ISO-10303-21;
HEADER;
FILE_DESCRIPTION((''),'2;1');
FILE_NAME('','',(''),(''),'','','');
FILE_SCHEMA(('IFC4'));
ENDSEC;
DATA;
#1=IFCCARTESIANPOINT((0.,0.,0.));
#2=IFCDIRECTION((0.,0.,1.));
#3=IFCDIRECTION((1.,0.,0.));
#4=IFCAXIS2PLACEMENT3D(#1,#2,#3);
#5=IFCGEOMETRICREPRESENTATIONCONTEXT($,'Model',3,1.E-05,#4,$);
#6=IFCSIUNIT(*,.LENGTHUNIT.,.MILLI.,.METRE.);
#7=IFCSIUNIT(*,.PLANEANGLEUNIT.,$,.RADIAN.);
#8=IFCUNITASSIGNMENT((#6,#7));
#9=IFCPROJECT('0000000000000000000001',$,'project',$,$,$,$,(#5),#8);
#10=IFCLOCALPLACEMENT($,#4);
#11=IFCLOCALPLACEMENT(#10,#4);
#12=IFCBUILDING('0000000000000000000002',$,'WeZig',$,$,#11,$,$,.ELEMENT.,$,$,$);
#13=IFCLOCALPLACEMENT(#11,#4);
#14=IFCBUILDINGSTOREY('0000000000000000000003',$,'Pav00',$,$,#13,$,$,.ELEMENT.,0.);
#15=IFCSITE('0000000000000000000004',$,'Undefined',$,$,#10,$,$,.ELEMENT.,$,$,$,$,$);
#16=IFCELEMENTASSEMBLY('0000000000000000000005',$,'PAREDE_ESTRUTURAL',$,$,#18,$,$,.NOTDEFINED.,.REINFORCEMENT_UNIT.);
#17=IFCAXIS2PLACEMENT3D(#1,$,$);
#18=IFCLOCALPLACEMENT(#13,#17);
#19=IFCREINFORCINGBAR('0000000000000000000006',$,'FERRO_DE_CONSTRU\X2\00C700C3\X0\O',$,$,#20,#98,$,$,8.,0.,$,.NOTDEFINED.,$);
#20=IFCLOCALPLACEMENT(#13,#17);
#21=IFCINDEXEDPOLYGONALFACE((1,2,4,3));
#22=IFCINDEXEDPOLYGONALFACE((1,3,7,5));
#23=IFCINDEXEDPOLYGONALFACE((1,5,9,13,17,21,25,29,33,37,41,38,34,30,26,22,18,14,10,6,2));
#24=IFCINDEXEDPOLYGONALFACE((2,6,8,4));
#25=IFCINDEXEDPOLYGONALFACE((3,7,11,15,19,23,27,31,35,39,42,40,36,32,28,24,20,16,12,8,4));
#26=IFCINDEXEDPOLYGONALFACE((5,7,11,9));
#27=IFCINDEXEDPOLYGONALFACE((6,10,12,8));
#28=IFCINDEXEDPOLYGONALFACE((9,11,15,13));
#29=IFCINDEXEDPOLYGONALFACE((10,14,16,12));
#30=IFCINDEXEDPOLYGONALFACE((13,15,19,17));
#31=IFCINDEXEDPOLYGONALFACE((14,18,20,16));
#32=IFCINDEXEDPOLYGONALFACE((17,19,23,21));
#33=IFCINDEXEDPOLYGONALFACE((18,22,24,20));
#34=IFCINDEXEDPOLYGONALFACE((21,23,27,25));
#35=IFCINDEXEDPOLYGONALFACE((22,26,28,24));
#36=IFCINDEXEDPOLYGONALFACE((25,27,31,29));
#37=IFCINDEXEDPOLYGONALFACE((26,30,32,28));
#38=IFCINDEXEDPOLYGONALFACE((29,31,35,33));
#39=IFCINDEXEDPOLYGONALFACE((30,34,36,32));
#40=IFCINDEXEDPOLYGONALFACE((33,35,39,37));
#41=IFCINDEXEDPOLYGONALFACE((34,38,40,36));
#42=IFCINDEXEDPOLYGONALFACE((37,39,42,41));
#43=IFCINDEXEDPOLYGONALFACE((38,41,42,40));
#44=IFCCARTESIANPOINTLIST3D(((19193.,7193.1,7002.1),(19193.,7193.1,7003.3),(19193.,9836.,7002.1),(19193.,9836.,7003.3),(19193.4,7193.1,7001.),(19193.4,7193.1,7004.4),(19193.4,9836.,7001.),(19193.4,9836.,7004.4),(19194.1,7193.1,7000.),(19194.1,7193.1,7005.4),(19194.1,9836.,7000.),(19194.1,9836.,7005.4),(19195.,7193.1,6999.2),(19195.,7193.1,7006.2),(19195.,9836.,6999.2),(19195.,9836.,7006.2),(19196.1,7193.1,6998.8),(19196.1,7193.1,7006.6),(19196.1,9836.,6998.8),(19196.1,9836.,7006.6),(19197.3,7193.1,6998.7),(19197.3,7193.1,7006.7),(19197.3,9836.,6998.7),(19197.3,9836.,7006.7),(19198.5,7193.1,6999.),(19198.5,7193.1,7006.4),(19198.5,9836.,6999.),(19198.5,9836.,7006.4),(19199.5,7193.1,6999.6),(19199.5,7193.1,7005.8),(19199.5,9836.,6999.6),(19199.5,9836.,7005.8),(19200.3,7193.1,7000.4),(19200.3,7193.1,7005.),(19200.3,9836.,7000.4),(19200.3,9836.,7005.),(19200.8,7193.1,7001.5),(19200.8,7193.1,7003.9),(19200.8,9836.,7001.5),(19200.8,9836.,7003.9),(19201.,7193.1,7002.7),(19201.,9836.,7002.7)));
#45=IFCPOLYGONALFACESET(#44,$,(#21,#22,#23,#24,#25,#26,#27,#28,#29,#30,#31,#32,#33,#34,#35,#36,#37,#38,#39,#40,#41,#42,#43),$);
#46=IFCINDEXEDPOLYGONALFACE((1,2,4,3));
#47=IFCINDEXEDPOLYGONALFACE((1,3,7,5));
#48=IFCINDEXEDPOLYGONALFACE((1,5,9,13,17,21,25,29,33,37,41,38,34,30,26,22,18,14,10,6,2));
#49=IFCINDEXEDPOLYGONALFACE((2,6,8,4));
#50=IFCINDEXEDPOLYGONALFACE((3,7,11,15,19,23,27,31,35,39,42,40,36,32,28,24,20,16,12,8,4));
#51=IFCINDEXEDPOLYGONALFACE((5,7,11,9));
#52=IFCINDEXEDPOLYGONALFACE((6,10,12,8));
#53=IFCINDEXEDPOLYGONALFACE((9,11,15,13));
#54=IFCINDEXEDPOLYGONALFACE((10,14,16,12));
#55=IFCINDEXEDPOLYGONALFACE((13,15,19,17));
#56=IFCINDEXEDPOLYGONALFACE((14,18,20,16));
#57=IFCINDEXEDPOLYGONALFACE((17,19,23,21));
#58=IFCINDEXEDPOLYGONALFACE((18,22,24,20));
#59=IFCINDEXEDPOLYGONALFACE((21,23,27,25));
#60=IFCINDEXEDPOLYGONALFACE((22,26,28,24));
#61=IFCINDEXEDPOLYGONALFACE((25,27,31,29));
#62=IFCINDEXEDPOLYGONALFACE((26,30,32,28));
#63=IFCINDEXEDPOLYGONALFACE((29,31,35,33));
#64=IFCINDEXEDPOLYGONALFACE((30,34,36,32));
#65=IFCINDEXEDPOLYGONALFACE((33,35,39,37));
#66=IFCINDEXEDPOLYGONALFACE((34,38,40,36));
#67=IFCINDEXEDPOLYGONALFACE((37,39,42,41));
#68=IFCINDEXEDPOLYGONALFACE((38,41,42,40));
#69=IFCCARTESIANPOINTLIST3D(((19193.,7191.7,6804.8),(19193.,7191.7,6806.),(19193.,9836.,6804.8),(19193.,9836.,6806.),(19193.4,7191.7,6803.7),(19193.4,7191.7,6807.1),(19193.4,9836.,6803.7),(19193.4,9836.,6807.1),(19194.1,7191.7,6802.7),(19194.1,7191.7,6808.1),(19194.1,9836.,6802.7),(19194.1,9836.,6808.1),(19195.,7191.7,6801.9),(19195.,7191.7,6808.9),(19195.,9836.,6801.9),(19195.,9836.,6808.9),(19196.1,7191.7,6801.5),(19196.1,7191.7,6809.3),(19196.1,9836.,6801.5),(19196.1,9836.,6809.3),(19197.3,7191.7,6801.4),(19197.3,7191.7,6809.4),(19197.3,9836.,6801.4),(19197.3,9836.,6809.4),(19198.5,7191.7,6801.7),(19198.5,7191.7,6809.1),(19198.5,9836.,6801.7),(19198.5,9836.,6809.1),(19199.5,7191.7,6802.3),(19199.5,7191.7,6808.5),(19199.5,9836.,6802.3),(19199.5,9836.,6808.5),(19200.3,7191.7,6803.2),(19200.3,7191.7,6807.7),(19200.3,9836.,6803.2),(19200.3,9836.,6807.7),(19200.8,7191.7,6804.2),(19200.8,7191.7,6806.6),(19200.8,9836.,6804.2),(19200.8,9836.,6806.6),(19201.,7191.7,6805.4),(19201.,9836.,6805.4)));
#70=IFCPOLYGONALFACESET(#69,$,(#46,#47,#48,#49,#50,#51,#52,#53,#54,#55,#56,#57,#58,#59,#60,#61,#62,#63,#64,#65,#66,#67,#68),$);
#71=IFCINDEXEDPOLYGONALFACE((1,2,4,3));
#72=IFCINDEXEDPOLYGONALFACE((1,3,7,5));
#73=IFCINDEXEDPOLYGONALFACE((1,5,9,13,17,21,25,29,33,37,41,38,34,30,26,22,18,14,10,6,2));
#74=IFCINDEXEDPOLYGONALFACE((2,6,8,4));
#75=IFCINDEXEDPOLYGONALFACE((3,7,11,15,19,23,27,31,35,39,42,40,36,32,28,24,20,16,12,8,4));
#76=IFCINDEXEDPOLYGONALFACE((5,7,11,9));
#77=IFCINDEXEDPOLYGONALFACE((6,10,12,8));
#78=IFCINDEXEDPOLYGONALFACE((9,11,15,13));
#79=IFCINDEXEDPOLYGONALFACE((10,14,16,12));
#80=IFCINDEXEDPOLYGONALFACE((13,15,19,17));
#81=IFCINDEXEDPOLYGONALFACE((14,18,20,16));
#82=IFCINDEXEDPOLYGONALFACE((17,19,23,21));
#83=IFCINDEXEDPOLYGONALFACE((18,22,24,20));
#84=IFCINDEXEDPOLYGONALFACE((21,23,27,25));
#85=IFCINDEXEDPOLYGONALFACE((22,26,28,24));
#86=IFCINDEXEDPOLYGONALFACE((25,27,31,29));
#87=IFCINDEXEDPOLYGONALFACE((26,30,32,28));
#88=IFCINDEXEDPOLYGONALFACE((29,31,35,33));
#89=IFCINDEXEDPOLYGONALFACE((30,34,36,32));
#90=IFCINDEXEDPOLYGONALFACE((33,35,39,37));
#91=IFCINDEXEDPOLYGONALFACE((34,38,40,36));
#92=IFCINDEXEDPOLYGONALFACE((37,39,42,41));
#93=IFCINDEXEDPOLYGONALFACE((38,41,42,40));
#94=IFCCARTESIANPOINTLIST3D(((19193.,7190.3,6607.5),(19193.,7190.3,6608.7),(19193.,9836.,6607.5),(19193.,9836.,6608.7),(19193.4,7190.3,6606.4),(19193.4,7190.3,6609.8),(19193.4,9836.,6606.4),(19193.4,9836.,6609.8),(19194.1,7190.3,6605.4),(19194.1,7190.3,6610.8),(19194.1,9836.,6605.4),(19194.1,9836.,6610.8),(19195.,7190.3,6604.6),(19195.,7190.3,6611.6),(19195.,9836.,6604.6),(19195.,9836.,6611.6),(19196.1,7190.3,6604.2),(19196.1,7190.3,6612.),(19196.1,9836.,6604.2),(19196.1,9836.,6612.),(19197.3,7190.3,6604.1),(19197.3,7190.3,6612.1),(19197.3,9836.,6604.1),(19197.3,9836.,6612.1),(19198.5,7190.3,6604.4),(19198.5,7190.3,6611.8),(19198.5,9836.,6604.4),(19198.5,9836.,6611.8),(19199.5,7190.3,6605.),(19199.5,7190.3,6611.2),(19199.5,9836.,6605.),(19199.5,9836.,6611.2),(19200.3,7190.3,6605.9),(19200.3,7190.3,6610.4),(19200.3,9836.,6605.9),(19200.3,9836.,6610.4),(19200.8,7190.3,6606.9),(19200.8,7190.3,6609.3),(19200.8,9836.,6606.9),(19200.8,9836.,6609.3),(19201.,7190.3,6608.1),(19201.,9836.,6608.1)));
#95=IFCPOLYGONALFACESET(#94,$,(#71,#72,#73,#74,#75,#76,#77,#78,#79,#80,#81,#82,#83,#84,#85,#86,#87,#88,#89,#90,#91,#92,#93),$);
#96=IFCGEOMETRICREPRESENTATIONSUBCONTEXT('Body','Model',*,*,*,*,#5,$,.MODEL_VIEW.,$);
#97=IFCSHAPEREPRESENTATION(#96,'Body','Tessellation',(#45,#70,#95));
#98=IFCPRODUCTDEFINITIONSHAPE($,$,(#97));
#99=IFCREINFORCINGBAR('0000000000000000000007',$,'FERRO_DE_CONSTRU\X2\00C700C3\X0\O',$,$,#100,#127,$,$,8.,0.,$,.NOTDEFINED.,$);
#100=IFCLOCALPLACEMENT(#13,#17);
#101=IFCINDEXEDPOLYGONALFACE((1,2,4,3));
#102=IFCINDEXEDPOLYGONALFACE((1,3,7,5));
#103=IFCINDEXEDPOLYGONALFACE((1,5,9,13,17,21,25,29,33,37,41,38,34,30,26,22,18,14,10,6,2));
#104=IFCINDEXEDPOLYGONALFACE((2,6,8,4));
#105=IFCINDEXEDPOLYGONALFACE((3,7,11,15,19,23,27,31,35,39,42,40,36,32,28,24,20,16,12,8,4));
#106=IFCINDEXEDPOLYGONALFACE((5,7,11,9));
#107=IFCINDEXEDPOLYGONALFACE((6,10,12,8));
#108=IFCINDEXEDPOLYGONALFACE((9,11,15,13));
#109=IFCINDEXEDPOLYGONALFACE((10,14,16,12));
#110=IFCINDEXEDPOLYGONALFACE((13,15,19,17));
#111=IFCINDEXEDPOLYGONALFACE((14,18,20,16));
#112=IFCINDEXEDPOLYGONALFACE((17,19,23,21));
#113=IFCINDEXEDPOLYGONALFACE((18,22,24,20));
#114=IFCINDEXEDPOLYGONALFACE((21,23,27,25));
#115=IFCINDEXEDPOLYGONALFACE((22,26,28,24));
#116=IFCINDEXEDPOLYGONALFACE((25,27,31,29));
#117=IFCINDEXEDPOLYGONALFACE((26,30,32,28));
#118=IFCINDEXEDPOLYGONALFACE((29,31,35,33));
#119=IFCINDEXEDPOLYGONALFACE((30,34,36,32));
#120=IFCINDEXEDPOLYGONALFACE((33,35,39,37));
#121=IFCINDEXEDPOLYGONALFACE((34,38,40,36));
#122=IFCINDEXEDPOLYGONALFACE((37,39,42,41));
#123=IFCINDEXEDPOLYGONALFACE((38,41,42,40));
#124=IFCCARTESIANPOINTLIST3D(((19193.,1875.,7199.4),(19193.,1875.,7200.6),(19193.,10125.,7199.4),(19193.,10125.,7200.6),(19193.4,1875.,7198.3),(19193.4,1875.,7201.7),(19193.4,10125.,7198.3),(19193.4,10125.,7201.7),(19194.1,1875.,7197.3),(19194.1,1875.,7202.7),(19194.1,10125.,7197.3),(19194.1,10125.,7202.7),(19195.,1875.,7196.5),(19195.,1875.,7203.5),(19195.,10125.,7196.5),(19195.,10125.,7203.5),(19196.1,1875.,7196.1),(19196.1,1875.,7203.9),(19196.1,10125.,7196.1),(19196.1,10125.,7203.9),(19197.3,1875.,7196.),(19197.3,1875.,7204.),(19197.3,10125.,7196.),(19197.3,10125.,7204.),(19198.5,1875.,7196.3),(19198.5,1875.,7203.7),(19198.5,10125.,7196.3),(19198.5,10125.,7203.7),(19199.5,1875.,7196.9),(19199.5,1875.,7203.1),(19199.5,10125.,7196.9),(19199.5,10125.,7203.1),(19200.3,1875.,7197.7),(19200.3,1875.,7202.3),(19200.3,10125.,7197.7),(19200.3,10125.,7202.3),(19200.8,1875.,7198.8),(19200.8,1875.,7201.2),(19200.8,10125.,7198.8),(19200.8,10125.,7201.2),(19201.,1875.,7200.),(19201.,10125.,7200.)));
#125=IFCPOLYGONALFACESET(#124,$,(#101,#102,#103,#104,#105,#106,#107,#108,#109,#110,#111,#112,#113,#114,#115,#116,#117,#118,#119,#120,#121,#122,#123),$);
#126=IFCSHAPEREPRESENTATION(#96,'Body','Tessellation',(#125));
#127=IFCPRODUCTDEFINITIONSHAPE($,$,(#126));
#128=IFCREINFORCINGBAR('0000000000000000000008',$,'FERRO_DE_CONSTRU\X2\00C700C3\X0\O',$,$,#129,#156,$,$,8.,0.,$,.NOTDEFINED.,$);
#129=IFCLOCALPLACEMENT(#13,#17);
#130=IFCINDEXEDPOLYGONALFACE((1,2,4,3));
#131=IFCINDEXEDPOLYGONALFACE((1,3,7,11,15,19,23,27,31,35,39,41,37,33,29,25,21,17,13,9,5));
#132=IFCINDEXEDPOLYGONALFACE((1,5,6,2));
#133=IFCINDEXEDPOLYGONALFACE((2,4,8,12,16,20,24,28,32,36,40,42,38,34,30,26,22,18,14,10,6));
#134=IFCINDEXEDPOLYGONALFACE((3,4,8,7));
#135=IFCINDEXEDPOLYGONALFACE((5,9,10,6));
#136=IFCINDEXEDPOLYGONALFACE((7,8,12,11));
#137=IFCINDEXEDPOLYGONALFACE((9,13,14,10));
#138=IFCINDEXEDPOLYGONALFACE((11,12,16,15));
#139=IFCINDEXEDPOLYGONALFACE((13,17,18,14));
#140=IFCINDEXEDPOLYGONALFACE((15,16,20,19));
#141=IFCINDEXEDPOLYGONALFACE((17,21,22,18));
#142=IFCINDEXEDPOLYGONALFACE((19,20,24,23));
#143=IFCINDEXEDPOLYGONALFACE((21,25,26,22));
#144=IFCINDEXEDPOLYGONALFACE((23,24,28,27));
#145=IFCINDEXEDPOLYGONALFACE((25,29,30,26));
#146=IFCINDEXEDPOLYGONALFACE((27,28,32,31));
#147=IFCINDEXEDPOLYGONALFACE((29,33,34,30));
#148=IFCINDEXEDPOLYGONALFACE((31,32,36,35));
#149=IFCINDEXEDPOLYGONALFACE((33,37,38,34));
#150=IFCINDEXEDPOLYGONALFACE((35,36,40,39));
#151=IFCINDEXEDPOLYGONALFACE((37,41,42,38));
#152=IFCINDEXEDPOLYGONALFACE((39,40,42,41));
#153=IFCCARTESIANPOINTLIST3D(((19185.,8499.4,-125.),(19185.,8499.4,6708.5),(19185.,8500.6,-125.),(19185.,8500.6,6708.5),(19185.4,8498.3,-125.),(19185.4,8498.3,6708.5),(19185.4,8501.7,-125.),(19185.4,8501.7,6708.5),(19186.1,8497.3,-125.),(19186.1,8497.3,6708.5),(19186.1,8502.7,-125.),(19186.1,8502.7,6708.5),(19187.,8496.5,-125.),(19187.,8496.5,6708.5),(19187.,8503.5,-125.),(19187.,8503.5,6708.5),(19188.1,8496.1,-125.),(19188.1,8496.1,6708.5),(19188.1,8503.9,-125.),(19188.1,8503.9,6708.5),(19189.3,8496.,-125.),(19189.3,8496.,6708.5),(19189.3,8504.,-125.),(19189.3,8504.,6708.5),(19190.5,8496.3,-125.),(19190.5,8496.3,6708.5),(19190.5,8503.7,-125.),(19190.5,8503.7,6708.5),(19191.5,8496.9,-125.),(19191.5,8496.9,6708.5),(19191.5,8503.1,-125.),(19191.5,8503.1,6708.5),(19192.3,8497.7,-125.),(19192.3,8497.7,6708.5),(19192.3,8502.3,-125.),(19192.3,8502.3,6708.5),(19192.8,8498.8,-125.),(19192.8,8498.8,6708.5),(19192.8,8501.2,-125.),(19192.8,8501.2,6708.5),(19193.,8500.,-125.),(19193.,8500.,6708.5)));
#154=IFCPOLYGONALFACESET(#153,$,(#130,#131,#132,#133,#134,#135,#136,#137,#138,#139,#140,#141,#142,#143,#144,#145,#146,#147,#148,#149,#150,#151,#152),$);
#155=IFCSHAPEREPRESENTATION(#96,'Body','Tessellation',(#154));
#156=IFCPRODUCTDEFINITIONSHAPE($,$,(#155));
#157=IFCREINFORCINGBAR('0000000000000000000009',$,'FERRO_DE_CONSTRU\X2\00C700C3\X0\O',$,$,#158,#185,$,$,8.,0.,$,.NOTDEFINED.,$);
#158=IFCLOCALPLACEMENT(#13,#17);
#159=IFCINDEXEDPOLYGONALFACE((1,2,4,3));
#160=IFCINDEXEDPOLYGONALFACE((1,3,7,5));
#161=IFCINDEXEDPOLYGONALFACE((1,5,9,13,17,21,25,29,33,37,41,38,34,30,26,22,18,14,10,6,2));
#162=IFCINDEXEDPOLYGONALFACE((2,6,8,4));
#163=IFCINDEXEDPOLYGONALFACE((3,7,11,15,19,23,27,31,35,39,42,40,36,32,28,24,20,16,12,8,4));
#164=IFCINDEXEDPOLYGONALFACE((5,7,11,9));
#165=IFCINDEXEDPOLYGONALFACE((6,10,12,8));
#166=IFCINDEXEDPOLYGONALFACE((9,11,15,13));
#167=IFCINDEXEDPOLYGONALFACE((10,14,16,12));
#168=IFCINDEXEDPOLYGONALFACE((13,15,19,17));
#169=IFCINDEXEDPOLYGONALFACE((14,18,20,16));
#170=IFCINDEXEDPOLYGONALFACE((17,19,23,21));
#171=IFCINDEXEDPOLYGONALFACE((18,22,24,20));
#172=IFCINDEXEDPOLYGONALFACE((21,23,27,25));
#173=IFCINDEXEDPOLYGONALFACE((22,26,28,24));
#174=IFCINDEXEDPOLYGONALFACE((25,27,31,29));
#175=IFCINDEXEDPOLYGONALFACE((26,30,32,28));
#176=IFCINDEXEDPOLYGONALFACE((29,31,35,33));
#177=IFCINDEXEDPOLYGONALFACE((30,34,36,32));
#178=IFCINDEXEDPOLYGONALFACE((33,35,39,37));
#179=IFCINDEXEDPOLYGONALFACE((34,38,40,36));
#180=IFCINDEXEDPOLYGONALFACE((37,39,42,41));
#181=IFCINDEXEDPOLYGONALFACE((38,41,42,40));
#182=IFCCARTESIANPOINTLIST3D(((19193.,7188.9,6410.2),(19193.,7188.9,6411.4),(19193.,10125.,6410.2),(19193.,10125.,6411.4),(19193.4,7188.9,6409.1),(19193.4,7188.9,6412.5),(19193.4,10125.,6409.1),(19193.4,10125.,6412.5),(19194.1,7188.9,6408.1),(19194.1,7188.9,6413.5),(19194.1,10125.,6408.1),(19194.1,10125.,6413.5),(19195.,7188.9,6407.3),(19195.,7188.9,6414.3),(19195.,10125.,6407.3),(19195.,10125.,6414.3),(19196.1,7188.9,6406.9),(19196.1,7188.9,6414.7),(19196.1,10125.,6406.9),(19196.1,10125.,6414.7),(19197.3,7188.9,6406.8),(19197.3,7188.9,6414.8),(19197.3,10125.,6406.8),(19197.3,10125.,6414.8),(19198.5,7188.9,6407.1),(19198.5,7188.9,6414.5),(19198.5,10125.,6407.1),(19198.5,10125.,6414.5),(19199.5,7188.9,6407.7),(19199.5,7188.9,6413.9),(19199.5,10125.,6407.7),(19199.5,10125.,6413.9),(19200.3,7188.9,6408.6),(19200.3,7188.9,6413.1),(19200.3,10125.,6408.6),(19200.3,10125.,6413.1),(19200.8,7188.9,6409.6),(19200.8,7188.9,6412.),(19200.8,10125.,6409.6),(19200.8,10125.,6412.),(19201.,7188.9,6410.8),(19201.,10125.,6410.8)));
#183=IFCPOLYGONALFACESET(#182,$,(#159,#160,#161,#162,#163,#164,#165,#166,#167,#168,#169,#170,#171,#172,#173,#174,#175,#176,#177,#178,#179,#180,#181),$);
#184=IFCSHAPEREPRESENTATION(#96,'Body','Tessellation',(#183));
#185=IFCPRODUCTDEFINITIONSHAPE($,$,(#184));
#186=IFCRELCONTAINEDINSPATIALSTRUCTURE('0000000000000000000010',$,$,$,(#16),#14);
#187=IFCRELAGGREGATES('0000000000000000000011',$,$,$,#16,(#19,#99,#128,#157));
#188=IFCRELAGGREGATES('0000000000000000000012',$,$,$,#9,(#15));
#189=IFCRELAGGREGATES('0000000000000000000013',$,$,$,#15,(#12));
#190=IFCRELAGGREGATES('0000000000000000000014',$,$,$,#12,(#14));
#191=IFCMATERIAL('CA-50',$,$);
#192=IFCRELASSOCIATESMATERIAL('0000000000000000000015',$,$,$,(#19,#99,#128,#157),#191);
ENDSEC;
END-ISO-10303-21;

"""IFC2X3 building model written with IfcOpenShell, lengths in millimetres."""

from ifc_helpers import new_model, entity, si_unit, frame, origin_with_axes, place, context, subcontext, project, spatial, source, transform, mapped, material, element, aggregate, save


model = new_model("IFC2X3")

# Units and contexts
model_context = context("Model", 3, precision=1e-05, world=origin_with_axes())
body_context = subcontext(model_context, "Body", "Model", "MODEL_VIEW")
ifc_project = project(units=[si_unit("LENGTHUNIT", "METRE", prefix="MILLI"), si_unit("PLANEANGLEUNIT", "RADIAN")], contexts=[model_context])

# Site, building, storey
site_placement = place(None, origin_with_axes())
site = spatial("IfcSite", under=ifc_project, at=site_placement, Name="Undefined", CompositionType="ELEMENT")
building_placement = place(site_placement, origin_with_axes())
building = spatial("IfcBuilding", under=site, at=building_placement, Name="WeZig", CompositionType="ELEMENT")
storey_placement = place(building_placement, origin_with_axes())
storey = spatial("IfcBuildingStorey", under=building, at=storey_placement, Name="Pav00", CompositionType="ELEMENT", Elevation=0.0)

# Element assembly
assembly_1_placement = place(storey_placement, origin_with_axes())
assembly_1 = element("IfcElementAssembly", 1, at=assembly_1_placement, inside=storey, Name="PAREDE_ESTRUTURAL", AssemblyPlace="NOTDEFINED", PredefinedType="REINFORCEMENT_UNIT")

# Reinforcing bars
ifc_material_1 = material(Name="CA-50")
shared_shape_1 = source(origin_with_axes(), body_context, "Body", "AdvancedSweptSolid", [
    entity("IfcSweptDiskSolid", entity("IfcTrimmedCurve", entity("IfcLine", entity("IfcCartesianPoint", [0.0, 0.0, 0.0]), entity("IfcVector", entity("IfcDirection", [1.0, 0.0, 0.0]), 1.0)), [entity("IfcParameterValue", 0.0)], [entity("IfcParameterValue", 2642.851014)], True, "PARAMETER"), 4.0, None, 0.0, 2642.9),
])
shared_shape_2 = source(origin_with_axes(), body_context, "Body", "AdvancedSweptSolid", [
    entity("IfcSweptDiskSolid", entity("IfcTrimmedCurve", entity("IfcLine", entity("IfcCartesianPoint", [0.0, 0.0, 0.0]), entity("IfcVector", entity("IfcDirection", [1.0, 0.0, 0.0]), 1.0)), [entity("IfcParameterValue", 0.0)], [entity("IfcParameterValue", 2644.264661)], True, "PARAMETER"), 4.0, None, 0.0, 2644.3),
])
shared_shape_3 = source(origin_with_axes(), body_context, "Body", "AdvancedSweptSolid", [
    entity("IfcSweptDiskSolid", entity("IfcTrimmedCurve", entity("IfcLine", entity("IfcCartesianPoint", [0.0, 0.0, 0.0]), entity("IfcVector", entity("IfcDirection", [1.0, 0.0, 0.0]), 1.0)), [entity("IfcParameterValue", 0.0)], [entity("IfcParameterValue", 2645.678308)], True, "PARAMETER"), 4.0, None, 0.0, 2645.7),
])
reinforcing_bar_1_placement = place(assembly_1_placement, frame((19197.0, 9836.0, 7002.7), z_axis=(1.0, 0.0, 0.0), x_axis=(0.0, -1.0, 0.0)))
reinforcing_bar_1 = element("IfcReinforcingBar", 2, at=reinforcing_bar_1_placement, material=ifc_material_1, Name="FERRO_DE_CONSTRUÇÃO", BarRole="NOTDEFINED", CrossSectionArea=0.0, NominalDiameter=8.0, context=body_context, shape_type="MappedRepresentation", body=[
    mapped(shared_shape_1, transform((0.0, 0.0, 0.0))),
    mapped(shared_shape_2, transform((0.0, 197.3, 0.0))),
    mapped(shared_shape_3, transform((0.0, 394.6, 0.0))),
])
shared_shape_4 = source(origin_with_axes(), body_context, "Body", "AdvancedSweptSolid", [
    entity("IfcSweptDiskSolid", entity("IfcTrimmedCurve", entity("IfcLine", entity("IfcCartesianPoint", [0.0, 0.0, 0.0]), entity("IfcVector", entity("IfcDirection", [1.0, 0.0, 0.0]), 1.0)), [entity("IfcParameterValue", 0.0)], [entity("IfcParameterValue", 8249.998938)], True, "PARAMETER"), 4.0, None, 0.0, 8250.0),
])
reinforcing_bar_2_placement = place(assembly_1_placement, frame((19197.0, 10125.0, 7200.0), z_axis=(1.0, 0.0, 0.0), x_axis=(0.0, -1.0, 0.0)))
reinforcing_bar_2 = element("IfcReinforcingBar", 3, at=reinforcing_bar_2_placement, material=ifc_material_1, Name="FERRO_DE_CONSTRUÇÃO", BarRole="NOTDEFINED", CrossSectionArea=0.0, NominalDiameter=8.0, context=body_context, shape_type="MappedRepresentation", body=[
    mapped(shared_shape_4, transform((0.0, 0.0, 0.0))),
])
shared_shape_5 = source(origin_with_axes(), body_context, "Body", "AdvancedSweptSolid", [
    entity("IfcSweptDiskSolid", entity("IfcTrimmedCurve", entity("IfcLine", entity("IfcCartesianPoint", [0.0, 0.0, 0.0]), entity("IfcVector", entity("IfcDirection", [1.0, 0.0, 0.0]), 1.0)), [entity("IfcParameterValue", 0.0)], [entity("IfcParameterValue", 6833.500084)], True, "PARAMETER"), 4.0, None, 0.0, 6833.5),
])
reinforcing_bar_3_placement = place(assembly_1_placement, frame((19189.0, 8500.0, 6708.5), z_axis=(1.0, 0.0, 0.0), x_axis=(0.0, 0.0, -1.0)))
reinforcing_bar_3 = element("IfcReinforcingBar", 4, at=reinforcing_bar_3_placement, material=ifc_material_1, Name="FERRO_DE_CONSTRUÇÃO", BarRole="NOTDEFINED", CrossSectionArea=0.0, NominalDiameter=8.0, context=body_context, shape_type="MappedRepresentation", body=[
    mapped(shared_shape_5, transform((0.0, 0.0, 0.0))),
])
shared_shape_6 = source(origin_with_axes(), body_context, "Body", "AdvancedSweptSolid", [
    entity("IfcSweptDiskSolid", entity("IfcTrimmedCurve", entity("IfcLine", entity("IfcCartesianPoint", [0.0, 0.0, 0.0]), entity("IfcVector", entity("IfcDirection", [1.0, 0.0, 0.0]), 1.0)), [entity("IfcParameterValue", 0.0)], [entity("IfcParameterValue", 2936.093446)], True, "PARAMETER"), 4.0, None, 0.0, 2936.1),
])
reinforcing_bar_4_placement = place(assembly_1_placement, frame((19197.0, 10125.0, 6410.8), z_axis=(1.0, 0.0, 0.0), x_axis=(0.0, -1.0, 0.0)))
reinforcing_bar_4 = element("IfcReinforcingBar", 5, at=reinforcing_bar_4_placement, material=ifc_material_1, Name="FERRO_DE_CONSTRUÇÃO", BarRole="NOTDEFINED", CrossSectionArea=0.0, NominalDiameter=8.0, context=body_context, shape_type="MappedRepresentation", body=[
    mapped(shared_shape_6, transform((0.0, 0.0, 0.0))),
])
aggregate(assembly_1, [reinforcing_bar_1, reinforcing_bar_2, reinforcing_bar_3, reinforcing_bar_4])

save(model, "model.ifc")
